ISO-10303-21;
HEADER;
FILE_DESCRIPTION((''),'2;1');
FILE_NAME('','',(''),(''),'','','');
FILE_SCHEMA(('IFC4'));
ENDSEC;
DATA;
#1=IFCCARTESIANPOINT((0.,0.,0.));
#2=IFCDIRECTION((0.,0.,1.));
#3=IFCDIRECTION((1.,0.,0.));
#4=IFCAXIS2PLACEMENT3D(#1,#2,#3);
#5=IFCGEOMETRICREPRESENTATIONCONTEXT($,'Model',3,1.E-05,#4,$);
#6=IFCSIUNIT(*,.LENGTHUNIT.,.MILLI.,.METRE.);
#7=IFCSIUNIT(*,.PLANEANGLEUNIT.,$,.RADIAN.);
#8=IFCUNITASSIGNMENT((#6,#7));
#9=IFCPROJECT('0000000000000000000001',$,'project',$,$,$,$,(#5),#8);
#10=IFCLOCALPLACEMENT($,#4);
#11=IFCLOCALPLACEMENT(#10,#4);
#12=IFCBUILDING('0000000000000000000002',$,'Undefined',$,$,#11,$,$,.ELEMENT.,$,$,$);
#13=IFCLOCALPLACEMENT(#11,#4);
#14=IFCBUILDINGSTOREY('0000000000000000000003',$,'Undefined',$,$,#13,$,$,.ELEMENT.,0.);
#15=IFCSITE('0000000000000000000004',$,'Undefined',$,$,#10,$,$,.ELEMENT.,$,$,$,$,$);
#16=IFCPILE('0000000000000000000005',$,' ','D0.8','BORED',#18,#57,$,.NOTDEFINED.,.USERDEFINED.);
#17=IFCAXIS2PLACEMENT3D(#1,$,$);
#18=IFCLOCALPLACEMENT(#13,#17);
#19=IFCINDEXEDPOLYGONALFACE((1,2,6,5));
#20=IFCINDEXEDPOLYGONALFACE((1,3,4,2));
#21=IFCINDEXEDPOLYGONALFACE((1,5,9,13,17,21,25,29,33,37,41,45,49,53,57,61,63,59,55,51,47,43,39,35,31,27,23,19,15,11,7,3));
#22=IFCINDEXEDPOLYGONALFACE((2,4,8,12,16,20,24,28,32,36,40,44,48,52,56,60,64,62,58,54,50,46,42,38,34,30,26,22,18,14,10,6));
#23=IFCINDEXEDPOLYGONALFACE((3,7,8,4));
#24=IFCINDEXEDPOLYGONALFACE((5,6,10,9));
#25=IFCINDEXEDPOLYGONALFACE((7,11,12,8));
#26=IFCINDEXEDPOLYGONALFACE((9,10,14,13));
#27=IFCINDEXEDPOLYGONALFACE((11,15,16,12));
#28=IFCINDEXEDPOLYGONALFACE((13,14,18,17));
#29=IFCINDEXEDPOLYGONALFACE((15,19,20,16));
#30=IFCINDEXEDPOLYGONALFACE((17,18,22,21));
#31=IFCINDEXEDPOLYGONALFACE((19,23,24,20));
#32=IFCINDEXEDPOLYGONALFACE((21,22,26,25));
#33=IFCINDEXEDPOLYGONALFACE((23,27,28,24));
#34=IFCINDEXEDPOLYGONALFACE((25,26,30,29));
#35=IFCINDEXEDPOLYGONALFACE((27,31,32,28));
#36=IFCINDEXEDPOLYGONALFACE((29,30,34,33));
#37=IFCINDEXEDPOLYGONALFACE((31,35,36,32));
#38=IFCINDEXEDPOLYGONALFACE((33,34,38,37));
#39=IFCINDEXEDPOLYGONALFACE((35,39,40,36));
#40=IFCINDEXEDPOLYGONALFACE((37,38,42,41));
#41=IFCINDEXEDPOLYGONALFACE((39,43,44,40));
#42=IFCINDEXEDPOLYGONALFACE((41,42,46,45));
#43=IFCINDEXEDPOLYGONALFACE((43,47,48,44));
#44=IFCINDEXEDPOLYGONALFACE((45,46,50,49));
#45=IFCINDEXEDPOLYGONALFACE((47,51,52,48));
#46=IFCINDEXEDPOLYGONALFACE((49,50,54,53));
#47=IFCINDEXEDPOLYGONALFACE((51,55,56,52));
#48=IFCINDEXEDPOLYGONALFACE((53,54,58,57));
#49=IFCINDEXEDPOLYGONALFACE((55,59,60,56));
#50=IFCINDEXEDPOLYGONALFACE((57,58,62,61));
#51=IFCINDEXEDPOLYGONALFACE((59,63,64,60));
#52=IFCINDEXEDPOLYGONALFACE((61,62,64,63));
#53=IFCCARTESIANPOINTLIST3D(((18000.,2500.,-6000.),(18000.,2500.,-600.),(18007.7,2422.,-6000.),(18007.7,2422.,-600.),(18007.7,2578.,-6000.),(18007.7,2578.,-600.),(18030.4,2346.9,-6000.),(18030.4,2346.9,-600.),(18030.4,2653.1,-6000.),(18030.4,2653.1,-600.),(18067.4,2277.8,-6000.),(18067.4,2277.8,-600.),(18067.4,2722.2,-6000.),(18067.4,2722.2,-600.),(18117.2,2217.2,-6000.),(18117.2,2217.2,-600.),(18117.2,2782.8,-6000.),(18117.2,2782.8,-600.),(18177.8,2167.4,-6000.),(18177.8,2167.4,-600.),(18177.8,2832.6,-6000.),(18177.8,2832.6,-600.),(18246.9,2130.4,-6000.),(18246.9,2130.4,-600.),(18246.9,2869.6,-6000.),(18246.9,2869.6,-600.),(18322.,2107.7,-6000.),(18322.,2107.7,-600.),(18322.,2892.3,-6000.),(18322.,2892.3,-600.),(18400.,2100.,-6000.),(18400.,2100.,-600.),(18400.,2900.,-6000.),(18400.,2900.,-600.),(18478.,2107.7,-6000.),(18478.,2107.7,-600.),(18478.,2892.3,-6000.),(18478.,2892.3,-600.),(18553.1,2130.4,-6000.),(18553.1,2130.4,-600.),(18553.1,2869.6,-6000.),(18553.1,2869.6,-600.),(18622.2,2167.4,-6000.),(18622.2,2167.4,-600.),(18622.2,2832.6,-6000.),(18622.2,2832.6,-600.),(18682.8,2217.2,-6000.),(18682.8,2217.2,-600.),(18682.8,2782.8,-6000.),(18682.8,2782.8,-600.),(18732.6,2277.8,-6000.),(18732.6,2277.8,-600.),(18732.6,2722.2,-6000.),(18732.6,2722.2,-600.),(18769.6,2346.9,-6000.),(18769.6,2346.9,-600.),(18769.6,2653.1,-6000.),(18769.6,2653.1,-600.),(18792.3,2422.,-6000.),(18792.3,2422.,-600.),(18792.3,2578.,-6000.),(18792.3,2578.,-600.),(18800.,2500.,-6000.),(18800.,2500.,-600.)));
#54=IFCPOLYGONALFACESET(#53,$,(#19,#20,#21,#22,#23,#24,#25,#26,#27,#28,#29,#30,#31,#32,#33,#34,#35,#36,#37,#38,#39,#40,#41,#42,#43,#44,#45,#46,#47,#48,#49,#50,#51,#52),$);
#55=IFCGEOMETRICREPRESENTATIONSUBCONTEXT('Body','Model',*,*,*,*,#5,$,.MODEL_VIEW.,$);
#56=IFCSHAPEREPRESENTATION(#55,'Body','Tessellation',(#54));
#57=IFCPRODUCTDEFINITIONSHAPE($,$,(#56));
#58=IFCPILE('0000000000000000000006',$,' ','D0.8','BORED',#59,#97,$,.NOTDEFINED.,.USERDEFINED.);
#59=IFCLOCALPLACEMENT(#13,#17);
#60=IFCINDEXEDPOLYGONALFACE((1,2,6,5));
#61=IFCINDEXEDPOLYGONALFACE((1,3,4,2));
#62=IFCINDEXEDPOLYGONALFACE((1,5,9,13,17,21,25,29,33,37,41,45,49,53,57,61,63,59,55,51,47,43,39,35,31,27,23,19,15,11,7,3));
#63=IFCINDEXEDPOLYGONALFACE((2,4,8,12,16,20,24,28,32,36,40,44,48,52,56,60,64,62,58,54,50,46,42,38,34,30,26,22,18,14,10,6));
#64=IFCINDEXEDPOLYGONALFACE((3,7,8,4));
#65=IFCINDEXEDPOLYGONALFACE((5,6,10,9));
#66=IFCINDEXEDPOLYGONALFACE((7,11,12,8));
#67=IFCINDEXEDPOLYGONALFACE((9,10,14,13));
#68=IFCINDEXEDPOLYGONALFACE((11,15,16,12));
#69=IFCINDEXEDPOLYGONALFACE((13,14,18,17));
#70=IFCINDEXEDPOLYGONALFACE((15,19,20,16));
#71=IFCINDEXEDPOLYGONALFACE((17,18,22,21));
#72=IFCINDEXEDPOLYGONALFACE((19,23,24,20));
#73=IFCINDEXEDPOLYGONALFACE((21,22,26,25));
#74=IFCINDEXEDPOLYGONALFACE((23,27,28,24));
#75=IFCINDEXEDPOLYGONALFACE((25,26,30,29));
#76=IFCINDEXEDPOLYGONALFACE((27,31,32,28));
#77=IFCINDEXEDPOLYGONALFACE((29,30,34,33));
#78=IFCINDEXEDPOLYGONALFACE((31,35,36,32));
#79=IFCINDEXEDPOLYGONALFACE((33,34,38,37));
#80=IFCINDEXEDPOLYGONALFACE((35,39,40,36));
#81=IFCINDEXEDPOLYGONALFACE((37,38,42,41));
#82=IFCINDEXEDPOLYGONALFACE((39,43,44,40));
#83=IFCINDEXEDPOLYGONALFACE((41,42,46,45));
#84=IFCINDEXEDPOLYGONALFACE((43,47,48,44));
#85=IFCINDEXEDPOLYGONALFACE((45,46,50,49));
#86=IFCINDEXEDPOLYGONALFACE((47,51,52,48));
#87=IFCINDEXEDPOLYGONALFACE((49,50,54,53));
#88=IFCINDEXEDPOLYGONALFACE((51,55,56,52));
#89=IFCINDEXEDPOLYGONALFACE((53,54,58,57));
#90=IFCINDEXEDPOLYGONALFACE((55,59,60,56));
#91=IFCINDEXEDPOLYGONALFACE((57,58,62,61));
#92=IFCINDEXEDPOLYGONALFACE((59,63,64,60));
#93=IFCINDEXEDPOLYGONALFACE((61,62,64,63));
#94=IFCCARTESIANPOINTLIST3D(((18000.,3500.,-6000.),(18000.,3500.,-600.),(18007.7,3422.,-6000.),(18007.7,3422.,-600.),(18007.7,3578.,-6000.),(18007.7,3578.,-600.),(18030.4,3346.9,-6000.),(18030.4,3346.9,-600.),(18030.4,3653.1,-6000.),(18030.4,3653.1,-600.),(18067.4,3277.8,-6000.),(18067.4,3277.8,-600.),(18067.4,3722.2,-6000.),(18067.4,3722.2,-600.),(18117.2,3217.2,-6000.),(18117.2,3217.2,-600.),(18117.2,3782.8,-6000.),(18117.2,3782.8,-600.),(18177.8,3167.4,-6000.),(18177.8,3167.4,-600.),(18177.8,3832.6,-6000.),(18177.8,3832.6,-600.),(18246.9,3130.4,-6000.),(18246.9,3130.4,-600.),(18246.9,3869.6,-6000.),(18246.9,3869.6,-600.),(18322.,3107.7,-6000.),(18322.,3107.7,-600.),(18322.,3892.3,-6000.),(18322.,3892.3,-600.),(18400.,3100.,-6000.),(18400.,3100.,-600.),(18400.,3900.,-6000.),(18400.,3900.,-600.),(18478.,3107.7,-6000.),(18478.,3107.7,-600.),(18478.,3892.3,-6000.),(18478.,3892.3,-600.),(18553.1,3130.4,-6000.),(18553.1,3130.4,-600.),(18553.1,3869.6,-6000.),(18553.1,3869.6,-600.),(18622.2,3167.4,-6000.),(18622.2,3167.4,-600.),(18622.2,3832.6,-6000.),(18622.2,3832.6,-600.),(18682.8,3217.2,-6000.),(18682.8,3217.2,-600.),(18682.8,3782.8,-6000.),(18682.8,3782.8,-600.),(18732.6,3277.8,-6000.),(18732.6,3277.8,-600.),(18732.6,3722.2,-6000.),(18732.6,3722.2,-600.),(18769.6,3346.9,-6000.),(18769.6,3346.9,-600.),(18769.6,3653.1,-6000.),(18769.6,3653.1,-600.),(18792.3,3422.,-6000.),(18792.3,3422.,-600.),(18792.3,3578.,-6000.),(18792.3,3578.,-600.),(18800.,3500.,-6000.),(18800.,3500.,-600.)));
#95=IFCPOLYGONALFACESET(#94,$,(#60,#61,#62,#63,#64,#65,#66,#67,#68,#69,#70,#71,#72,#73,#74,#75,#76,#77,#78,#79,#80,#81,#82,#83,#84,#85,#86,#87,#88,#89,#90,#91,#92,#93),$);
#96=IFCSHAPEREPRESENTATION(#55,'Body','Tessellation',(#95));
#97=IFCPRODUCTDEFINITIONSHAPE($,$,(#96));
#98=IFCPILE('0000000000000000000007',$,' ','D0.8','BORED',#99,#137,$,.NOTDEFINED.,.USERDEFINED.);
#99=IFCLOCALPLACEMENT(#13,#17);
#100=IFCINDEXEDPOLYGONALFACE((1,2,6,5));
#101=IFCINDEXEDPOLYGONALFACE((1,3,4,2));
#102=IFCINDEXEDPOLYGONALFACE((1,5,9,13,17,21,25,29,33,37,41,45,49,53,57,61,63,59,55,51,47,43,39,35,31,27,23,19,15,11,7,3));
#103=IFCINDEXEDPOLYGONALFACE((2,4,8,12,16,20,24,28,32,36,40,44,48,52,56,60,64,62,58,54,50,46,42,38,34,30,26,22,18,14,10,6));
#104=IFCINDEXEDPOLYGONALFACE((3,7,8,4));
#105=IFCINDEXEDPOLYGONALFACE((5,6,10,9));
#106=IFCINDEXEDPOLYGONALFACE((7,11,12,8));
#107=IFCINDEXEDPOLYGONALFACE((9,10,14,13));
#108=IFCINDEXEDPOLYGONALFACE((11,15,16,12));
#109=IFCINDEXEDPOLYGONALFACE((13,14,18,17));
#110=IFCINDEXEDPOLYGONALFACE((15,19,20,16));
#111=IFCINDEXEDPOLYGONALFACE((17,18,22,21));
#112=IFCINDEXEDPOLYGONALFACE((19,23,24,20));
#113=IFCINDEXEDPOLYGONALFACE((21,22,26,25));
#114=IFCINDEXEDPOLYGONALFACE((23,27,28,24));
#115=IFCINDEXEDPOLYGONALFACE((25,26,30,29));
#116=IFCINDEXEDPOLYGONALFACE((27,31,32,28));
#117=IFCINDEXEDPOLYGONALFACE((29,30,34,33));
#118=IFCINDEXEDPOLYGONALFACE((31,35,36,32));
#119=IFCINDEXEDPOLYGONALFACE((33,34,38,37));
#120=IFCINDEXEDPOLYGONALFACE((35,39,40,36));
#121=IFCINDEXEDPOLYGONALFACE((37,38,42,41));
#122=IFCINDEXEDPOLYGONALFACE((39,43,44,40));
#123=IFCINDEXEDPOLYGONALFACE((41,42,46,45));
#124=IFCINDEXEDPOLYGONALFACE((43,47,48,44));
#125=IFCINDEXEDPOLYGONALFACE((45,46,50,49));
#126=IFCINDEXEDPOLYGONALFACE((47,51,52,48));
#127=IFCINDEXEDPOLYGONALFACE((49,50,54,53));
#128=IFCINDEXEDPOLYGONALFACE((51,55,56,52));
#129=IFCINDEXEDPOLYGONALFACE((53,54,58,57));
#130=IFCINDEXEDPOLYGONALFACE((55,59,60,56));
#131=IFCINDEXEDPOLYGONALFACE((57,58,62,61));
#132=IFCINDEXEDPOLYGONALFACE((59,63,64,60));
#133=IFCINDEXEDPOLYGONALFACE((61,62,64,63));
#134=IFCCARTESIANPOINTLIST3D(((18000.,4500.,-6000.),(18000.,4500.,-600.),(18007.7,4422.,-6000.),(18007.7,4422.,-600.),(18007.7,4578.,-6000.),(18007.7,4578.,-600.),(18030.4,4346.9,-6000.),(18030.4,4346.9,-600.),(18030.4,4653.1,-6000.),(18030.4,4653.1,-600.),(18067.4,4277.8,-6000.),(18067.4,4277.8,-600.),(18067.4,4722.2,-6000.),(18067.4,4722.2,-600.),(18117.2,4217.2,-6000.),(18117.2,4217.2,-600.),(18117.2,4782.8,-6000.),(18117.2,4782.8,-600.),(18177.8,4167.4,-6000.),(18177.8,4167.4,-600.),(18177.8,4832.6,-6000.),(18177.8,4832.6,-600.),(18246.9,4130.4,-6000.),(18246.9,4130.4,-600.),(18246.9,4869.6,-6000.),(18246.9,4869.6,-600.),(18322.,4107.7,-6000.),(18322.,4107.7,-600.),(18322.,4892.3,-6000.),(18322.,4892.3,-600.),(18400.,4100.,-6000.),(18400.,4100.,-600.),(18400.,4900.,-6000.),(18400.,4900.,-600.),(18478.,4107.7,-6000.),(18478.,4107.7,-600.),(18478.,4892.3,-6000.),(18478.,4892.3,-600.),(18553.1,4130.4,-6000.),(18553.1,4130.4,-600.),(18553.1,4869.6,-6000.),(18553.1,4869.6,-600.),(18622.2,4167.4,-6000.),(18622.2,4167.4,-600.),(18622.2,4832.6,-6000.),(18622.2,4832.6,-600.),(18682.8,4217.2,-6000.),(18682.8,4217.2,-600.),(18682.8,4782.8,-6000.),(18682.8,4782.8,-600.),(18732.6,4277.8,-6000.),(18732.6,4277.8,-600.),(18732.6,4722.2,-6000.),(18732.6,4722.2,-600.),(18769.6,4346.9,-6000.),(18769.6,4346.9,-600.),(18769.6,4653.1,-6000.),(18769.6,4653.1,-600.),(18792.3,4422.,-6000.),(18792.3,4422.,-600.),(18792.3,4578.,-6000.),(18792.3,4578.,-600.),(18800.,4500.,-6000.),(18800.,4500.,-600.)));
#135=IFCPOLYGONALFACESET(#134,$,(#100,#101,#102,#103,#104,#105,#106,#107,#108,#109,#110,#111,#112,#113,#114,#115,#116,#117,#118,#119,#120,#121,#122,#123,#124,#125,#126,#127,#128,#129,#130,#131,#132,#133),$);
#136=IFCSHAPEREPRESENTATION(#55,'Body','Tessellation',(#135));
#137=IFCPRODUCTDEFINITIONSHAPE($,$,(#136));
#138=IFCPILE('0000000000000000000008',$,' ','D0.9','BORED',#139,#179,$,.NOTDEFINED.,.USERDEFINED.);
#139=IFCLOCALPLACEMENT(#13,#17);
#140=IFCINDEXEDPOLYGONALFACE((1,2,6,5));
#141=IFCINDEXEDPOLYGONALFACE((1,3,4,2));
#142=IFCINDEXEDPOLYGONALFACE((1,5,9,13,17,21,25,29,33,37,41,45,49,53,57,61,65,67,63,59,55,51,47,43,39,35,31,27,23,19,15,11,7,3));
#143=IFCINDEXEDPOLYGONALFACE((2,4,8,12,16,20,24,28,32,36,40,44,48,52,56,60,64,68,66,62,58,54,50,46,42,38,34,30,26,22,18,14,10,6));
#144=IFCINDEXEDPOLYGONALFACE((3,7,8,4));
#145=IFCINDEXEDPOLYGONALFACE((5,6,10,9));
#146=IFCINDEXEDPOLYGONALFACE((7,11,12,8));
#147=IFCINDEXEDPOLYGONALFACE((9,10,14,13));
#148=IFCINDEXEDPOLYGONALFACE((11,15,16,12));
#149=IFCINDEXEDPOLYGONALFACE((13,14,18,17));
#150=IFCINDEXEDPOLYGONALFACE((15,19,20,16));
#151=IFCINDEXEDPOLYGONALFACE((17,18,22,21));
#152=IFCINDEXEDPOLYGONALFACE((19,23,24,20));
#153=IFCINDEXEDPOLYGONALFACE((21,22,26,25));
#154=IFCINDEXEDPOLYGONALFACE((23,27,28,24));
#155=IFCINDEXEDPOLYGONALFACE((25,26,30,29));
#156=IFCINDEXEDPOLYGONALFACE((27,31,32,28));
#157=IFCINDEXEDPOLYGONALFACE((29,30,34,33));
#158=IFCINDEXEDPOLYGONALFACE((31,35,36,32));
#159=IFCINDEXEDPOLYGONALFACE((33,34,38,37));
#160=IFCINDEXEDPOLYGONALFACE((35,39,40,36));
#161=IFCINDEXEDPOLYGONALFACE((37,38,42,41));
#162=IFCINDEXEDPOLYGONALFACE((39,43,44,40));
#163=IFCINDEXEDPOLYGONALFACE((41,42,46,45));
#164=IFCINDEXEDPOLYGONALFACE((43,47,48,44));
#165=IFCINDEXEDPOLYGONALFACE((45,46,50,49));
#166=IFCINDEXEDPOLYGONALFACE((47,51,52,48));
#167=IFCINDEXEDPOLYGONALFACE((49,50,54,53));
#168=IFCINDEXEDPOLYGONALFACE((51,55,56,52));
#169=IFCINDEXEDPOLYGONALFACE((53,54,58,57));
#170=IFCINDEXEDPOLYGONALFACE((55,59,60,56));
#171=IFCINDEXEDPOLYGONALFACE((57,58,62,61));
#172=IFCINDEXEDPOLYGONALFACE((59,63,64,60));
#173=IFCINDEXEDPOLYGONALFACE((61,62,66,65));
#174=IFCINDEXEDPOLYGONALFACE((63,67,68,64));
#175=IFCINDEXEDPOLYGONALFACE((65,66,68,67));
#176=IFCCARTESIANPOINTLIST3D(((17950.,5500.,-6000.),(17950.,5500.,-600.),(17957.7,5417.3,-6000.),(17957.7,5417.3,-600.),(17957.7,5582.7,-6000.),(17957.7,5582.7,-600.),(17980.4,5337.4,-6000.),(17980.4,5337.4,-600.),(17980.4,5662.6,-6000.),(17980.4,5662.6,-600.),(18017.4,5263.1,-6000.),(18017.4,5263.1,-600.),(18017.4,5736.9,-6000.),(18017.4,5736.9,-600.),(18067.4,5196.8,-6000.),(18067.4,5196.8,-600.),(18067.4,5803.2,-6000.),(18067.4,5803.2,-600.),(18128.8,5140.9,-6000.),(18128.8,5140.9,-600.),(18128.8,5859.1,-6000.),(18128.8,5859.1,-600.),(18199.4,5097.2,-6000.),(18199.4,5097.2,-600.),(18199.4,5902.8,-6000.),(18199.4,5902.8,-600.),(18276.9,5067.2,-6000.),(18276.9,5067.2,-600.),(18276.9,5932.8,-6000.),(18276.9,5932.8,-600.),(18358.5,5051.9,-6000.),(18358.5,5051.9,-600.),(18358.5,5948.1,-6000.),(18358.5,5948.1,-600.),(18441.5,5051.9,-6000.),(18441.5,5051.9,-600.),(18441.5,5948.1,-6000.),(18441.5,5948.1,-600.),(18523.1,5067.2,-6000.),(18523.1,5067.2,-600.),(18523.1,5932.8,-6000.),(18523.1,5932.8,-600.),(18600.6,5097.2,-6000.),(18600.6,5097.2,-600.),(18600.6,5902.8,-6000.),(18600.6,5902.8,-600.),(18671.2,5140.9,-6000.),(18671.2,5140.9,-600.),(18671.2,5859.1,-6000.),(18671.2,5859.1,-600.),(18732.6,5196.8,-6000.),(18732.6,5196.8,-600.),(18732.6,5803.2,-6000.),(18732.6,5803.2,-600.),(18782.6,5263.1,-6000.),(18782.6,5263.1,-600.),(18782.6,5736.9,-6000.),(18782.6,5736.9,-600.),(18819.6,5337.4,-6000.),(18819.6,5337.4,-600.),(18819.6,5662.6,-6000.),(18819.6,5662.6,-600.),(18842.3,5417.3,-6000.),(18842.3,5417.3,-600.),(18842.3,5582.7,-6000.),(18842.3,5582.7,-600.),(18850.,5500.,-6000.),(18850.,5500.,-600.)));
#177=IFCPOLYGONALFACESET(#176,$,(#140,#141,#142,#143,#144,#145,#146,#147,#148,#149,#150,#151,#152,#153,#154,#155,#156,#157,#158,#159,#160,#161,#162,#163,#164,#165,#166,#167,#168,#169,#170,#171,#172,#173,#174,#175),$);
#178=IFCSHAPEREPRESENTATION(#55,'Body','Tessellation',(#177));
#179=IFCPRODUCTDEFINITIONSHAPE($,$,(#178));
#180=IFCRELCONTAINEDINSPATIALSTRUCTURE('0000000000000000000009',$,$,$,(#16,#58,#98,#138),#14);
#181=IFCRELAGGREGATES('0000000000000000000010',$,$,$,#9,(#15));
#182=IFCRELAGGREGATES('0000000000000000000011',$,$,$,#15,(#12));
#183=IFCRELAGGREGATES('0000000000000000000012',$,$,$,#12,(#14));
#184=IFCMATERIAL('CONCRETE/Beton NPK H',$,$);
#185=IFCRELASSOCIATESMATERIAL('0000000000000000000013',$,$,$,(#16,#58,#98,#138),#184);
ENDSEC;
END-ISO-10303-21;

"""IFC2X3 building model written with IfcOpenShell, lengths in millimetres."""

from ifc_helpers import new_model, si_unit, frame, origin_with_axes, origin_2d_with_axis, place, context, subcontext, project, spatial, circle, extrude, material, element, save


model = new_model("IFC2X3")

# Units and contexts
model_context = context("Model", 3, precision=1e-05, world=origin_with_axes())
body_context = subcontext(model_context, "Body", "Model", "MODEL_VIEW")
ifc_project = project(units=[si_unit("LENGTHUNIT", "METRE", prefix="MILLI"), si_unit("PLANEANGLEUNIT", "RADIAN")], contexts=[model_context])

# Site, building, storey
site_placement = place(None, origin_with_axes())
site = spatial("IfcSite", under=ifc_project, at=site_placement, Name="Undefined", CompositionType="ELEMENT")
building_placement = place(site_placement, origin_with_axes())
building = spatial("IfcBuilding", under=site, at=building_placement, Name="Undefined", CompositionType="ELEMENT")
storey_placement = place(building_placement, origin_with_axes())
storey = spatial("IfcBuildingStorey", under=building, at=storey_placement, Name="Undefined", CompositionType="ELEMENT", Elevation=0.0)

# Piles
ifc_material_1 = material(Name="CONCRETE/Beton NPK H")
for number, where, z_axis, x_axis, name in (
    (1, (18400.0, 2500.0, -6000.0), (0.0, 1.0, 0.0), (0.0, 0.0, 1.0), " "),
    (2, (18400.0, 3500.0, -6000.0), (0.0, 1.0, 0.0), (0.0, 0.0, 1.0), " "),
    (3, (18400.0, 4500.0, -6000.0), (0.0, 1.0, 0.0), (0.0, 0.0, 1.0), " "),
):
    element("IfcPile", number, at=place(storey_placement, frame(where, z_axis=z_axis, x_axis=x_axis)), inside=storey, material=ifc_material_1, Name=name, Description="D0.8", ObjectType="BORED", ConstructionType="USERDEFINED", PredefinedType="NOTDEFINED", context=body_context, shape_type="SweptSolid", body=[
        extrude(circle(Radius=400.0, at=origin_2d_with_axis()), frame((5400.0, 0.0, 0.0), z_axis=(-1.0, 0.0, 0.0), x_axis=(0.0, -1.0, 0.0)), (0.0, 0.0, 1.0), 5400.0),
    ])
pile_1_placement = place(storey_placement, frame((18400.0, 5500.0, -6000.0), z_axis=(0.0, 1.0, 0.0), x_axis=(0.0, 0.0, 1.0)))
element("IfcPile", 4, at=pile_1_placement, inside=storey, material=ifc_material_1, Name=" ", Description="D0.9", ObjectType="BORED", ConstructionType="USERDEFINED", PredefinedType="NOTDEFINED", context=body_context, shape_type="SweptSolid", body=[
    extrude(circle(Radius=450.0, at=origin_2d_with_axis()), frame((5400.0, 0.0, 0.0), z_axis=(-1.0, 0.0, 0.0), x_axis=(0.0, -1.0, 0.0)), (0.0, 0.0, 1.0), 5400.0),
])

save(model, "model.ifc")
